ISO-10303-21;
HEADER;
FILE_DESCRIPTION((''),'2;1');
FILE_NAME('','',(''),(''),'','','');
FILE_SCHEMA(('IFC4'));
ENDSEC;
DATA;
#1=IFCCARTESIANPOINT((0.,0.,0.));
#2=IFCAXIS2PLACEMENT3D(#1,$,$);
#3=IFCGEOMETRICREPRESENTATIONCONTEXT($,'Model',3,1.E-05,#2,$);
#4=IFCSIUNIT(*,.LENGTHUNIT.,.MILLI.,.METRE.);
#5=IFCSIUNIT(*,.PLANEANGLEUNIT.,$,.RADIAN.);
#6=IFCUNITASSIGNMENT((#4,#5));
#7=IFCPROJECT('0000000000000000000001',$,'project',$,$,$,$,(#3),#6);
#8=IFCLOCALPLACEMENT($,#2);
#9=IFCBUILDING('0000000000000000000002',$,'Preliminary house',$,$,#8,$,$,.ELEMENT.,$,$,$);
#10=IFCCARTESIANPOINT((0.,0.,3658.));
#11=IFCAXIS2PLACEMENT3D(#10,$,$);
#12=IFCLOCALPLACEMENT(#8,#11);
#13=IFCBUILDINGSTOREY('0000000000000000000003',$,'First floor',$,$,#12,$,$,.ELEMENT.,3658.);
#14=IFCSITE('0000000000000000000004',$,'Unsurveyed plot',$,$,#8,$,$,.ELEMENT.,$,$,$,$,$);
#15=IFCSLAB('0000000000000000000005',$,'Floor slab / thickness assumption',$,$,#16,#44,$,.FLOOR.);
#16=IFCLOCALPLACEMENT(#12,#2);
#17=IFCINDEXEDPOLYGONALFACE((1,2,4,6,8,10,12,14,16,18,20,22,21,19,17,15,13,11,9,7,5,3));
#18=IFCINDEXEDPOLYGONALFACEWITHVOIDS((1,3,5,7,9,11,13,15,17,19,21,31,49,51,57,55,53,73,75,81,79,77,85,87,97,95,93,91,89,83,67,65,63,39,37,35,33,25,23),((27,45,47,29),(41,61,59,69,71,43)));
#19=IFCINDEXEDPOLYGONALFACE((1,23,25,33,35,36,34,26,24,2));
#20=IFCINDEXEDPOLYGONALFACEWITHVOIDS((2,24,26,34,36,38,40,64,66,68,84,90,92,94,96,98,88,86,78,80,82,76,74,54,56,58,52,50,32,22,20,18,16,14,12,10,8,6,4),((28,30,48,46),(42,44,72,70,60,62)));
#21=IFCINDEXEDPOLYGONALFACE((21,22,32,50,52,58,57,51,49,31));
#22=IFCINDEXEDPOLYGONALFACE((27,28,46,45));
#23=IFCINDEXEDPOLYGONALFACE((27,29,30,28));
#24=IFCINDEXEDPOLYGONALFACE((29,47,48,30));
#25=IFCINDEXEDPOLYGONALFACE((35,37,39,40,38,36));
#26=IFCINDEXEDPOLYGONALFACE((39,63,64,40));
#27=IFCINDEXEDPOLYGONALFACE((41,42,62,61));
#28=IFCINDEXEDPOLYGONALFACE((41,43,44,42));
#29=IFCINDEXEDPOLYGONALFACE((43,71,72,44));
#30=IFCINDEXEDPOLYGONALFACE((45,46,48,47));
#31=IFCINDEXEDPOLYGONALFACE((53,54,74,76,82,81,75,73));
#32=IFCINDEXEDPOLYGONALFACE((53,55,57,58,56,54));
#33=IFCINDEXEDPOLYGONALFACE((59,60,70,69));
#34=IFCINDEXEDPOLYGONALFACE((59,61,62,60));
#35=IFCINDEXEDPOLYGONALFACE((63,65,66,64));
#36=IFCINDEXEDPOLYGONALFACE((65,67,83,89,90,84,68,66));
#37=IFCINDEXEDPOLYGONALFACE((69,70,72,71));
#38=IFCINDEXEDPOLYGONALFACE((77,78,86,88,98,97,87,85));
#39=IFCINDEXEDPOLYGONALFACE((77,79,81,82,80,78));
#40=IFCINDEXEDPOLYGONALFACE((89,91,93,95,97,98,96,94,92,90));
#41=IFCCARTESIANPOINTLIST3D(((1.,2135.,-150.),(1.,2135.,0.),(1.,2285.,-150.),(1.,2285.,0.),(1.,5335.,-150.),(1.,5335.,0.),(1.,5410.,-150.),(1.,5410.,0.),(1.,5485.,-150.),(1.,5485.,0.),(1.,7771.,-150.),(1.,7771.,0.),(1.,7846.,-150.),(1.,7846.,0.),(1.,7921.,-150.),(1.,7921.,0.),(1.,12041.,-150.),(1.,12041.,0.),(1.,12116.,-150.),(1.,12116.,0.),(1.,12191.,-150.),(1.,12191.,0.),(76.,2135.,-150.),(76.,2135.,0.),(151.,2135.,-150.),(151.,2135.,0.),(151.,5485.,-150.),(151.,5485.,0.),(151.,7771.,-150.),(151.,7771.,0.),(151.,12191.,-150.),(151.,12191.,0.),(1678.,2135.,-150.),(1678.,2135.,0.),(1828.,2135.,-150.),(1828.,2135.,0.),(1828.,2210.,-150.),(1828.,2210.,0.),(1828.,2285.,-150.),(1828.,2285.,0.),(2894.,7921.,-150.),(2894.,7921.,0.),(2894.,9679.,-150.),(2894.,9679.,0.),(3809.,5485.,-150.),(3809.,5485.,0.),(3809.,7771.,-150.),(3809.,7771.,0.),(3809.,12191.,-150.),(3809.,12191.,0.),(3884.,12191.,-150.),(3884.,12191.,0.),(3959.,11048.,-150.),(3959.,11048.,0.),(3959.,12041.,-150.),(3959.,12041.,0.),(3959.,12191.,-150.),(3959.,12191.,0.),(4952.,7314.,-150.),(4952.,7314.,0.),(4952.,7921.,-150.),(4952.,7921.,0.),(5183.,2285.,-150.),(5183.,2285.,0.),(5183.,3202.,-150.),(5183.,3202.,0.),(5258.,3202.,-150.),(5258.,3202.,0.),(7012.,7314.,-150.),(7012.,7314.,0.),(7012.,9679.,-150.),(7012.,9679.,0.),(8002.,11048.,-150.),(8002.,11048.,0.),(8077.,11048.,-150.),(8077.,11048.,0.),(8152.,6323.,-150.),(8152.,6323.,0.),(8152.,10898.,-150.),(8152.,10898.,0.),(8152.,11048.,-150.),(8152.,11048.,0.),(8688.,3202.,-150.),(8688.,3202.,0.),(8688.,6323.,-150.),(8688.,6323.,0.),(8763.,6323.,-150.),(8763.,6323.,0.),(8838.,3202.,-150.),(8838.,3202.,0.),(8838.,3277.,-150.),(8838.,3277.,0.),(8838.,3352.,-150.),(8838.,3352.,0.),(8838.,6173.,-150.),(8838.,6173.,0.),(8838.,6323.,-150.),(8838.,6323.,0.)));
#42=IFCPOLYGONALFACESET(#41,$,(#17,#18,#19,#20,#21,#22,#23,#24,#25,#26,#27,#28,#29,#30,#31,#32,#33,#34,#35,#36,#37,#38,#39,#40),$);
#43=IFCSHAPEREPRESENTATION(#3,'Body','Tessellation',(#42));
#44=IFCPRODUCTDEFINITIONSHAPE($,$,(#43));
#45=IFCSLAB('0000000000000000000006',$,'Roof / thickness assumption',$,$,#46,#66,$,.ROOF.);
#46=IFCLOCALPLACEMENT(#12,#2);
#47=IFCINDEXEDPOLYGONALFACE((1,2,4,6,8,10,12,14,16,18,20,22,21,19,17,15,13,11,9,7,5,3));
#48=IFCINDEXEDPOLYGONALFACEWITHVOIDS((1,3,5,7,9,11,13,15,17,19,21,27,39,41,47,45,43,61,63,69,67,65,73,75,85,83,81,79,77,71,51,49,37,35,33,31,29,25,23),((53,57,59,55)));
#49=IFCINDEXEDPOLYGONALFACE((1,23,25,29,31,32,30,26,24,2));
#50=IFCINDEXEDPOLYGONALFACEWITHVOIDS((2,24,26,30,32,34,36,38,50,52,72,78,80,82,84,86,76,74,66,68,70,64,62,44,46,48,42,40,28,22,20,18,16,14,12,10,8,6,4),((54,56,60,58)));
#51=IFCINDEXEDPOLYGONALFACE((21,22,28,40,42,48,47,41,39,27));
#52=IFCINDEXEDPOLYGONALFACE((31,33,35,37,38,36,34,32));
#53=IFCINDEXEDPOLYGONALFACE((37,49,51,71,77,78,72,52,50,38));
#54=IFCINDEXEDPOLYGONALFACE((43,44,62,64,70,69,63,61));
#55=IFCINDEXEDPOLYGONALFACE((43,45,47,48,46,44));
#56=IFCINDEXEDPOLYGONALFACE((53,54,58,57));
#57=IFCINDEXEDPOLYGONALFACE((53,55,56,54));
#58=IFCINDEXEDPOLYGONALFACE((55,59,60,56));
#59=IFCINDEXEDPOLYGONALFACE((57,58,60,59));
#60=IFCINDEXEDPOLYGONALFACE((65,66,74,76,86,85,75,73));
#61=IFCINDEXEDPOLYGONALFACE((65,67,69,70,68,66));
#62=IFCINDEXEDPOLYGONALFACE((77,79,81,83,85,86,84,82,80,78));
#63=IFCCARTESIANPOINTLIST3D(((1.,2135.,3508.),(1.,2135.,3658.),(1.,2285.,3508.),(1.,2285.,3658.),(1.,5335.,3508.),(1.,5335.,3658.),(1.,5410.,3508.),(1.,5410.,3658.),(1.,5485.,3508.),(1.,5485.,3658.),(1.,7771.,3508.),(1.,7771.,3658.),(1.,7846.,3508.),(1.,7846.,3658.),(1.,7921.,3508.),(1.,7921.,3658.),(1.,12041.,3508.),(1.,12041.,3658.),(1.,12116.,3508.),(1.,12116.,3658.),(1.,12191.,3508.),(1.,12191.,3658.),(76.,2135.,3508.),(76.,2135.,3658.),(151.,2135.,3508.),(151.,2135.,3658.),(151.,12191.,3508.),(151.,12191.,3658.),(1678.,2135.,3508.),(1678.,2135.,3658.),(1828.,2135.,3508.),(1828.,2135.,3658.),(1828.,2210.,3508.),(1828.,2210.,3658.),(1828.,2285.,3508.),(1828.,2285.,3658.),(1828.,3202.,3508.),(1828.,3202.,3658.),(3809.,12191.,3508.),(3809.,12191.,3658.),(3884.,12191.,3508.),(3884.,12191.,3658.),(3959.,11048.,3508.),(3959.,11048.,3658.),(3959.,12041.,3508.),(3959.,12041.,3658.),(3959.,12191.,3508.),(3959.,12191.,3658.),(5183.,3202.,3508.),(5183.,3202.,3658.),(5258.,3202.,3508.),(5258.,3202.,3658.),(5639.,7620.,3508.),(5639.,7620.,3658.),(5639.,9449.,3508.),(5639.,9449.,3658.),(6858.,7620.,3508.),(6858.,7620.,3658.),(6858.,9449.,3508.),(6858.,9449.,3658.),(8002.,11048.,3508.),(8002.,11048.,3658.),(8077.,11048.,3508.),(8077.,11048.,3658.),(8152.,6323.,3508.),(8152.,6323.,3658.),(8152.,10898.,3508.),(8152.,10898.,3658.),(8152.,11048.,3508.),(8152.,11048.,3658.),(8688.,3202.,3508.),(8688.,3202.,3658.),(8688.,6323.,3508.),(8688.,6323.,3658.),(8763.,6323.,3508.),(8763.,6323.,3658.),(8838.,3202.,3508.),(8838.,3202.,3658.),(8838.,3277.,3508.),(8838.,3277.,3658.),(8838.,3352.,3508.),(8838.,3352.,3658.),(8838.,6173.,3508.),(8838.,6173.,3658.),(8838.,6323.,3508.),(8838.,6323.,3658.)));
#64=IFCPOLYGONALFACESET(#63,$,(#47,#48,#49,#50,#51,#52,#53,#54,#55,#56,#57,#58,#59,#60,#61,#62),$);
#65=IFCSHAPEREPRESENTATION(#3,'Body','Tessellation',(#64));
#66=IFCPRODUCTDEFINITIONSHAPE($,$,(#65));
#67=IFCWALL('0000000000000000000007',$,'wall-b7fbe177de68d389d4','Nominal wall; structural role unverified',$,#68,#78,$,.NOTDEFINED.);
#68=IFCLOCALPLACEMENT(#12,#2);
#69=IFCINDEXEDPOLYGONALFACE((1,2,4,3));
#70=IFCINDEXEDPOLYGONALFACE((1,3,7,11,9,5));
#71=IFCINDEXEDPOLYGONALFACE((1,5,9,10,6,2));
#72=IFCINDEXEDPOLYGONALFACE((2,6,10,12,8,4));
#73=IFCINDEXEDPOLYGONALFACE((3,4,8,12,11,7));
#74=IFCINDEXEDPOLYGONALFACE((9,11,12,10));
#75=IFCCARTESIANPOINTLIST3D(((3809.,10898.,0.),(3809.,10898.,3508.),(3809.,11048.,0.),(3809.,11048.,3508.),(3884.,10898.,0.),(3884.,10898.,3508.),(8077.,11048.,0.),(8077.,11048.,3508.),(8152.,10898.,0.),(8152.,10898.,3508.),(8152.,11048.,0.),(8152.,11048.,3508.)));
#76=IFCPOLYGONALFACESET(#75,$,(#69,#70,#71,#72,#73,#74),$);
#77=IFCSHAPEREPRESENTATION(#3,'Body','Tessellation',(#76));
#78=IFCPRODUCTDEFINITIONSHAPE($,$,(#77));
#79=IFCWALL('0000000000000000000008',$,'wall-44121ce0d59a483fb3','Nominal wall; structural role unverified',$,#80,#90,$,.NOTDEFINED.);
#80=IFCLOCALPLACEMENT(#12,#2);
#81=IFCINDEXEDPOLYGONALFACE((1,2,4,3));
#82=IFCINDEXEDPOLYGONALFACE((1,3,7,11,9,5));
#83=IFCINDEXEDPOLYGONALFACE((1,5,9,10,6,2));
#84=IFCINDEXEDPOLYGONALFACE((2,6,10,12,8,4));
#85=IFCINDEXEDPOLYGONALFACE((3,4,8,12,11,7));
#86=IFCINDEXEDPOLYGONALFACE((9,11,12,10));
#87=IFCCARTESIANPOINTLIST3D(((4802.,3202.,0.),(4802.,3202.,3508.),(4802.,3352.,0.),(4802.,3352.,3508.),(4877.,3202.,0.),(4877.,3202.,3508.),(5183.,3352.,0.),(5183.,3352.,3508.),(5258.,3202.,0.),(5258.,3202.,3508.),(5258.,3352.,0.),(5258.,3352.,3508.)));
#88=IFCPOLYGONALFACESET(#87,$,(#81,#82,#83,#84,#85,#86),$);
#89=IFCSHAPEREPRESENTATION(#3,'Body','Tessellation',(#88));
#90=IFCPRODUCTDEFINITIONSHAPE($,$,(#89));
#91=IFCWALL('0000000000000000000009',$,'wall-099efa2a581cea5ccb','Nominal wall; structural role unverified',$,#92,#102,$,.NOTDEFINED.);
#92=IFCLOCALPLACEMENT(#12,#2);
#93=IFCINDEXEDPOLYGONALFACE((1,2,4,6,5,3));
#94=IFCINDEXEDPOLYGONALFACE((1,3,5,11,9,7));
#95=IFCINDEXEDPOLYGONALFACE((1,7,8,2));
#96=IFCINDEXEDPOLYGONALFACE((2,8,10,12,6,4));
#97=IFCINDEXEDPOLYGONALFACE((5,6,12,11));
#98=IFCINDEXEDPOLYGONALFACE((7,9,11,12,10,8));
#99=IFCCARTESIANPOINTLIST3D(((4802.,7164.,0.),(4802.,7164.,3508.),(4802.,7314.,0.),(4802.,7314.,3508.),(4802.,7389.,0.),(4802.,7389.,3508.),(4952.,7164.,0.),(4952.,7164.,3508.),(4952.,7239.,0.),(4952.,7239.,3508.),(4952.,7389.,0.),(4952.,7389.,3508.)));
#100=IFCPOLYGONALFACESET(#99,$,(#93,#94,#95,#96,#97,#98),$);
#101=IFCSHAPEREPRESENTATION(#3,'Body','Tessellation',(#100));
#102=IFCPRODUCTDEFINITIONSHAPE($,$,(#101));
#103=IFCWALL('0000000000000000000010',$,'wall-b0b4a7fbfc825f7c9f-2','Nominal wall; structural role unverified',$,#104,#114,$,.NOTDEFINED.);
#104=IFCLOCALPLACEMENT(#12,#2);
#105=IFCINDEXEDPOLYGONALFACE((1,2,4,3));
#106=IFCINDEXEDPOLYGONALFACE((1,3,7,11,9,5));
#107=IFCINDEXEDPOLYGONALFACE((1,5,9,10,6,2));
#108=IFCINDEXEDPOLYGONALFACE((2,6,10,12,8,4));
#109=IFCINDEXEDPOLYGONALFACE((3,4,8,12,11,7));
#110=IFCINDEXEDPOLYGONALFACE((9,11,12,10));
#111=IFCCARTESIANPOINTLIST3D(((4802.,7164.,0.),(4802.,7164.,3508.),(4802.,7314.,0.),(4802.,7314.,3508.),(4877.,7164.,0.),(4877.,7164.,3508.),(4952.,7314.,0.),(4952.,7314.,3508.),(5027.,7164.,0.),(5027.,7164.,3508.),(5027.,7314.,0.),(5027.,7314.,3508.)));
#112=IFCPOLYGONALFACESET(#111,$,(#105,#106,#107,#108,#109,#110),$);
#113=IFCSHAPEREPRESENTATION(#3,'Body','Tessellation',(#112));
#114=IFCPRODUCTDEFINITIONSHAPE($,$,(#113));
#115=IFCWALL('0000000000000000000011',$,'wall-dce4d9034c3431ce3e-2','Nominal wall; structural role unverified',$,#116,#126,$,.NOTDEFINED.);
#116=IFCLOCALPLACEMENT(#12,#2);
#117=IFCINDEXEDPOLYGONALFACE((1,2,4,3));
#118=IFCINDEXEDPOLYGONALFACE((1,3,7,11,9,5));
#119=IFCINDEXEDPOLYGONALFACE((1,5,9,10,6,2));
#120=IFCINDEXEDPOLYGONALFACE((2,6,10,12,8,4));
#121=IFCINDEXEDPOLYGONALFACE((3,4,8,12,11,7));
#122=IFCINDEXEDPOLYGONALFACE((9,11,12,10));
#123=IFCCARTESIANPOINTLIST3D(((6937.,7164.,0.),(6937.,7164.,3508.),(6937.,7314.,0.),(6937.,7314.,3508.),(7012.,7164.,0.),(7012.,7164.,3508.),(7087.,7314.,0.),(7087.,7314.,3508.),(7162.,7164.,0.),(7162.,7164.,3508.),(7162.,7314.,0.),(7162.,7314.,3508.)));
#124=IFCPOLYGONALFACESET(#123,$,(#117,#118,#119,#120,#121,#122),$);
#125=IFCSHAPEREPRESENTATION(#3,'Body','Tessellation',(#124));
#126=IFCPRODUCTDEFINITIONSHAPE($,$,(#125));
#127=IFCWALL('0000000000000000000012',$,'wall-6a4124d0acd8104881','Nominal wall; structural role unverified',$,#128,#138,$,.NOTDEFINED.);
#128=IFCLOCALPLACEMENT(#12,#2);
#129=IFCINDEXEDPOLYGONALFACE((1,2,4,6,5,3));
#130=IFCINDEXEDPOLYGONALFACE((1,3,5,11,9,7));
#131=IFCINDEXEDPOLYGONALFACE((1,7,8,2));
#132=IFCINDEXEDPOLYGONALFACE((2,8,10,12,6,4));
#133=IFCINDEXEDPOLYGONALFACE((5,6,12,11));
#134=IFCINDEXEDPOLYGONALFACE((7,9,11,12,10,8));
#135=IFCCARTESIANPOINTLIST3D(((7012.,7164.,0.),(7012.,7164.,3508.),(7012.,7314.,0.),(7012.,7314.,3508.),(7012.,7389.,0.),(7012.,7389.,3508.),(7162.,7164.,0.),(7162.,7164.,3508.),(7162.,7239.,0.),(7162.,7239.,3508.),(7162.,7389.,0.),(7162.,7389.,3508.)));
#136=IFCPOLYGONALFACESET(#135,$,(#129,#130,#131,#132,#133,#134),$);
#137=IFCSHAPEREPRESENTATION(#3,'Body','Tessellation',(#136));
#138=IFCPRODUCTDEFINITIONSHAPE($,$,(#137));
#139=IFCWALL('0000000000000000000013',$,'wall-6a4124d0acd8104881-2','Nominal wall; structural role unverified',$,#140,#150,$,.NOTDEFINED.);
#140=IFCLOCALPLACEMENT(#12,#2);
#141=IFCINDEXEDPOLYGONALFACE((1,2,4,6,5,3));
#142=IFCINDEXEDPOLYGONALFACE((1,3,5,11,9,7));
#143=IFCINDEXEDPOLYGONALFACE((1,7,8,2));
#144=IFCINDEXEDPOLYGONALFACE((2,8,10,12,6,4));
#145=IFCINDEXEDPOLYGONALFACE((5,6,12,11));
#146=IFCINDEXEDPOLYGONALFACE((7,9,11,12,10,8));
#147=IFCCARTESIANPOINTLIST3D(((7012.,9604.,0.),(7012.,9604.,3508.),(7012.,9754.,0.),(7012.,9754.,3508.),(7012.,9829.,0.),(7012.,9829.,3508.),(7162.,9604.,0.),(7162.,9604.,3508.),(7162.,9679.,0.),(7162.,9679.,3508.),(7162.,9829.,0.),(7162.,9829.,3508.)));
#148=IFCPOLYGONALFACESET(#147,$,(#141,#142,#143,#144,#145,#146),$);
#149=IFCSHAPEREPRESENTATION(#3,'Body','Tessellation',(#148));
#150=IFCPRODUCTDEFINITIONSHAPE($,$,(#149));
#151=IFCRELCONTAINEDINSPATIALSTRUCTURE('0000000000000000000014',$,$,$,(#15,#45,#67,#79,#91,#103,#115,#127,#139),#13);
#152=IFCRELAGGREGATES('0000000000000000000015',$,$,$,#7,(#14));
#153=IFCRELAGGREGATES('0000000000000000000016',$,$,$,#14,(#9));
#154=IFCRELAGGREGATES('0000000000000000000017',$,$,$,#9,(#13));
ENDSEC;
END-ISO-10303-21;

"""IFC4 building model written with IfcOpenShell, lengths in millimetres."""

from ifc_helpers import new_model, si_unit, frame, origin, place, context, project, spatial, polyline, outline, extrude, element, save


model = new_model("IFC4")

# Units and contexts
model_context = context("Model", 3, precision=1e-05, world=origin())
ifc_project = project(units=[si_unit("LENGTHUNIT", "METRE", prefix="MILLI"), si_unit("PLANEANGLEUNIT", "RADIAN")], contexts=[model_context])

# Site, building, storey
placement_1 = place(None, origin())
site = spatial("IfcSite", under=ifc_project, at=placement_1, Name="Unsurveyed plot", CompositionType="ELEMENT")
building = spatial("IfcBuilding", under=site, at=placement_1, Name="Preliminary house", CompositionType="ELEMENT")
placement_2 = place(placement_1, frame((0.0, 0.0, 3658.0)))
storey = spatial("IfcBuildingStorey", under=building, at=placement_2, Name="First floor", CompositionType="ELEMENT", Elevation=3658.0)

# Slabs
element("IfcSlab", 1, at=placement_2, inside=storey, Name="Floor slab / thickness assumption", PredefinedType="FLOOR", context=model_context, shape_type="SweptSolid", body=[
    extrude(outline(polyline([(1.0, 2285.0), (1.0, 5335.0), (1.0, 5410.0), (1.0, 5485.0), (1.0, 7771.0), (1.0, 7846.0), (1.0, 7921.0), (1.0, 12041.0), (1.0, 12116.0), (1.0, 12191.0), (151.0, 12191.0), (3809.0, 12191.0), (3884.0, 12191.0), (3959.0, 12191.0), (3959.0, 12041.0), (3959.0, 11048.0), (8002.0, 11048.0), (8077.0, 11048.0), (8152.0, 11048.0), (8152.0, 10898.0), (8152.0, 6323.0), (8688.0, 6323.0), (8763.0, 6323.0), (8838.0, 6323.0), (8838.0, 6173.0), (8838.0, 3352.0), (8838.0, 3277.0), (8838.0, 3202.0), (8688.0, 3202.0), (5258.0, 3202.0), (5183.0, 3202.0), (5183.0, 2285.0), (1828.0, 2285.0), (1828.0, 2210.0), (1828.0, 2135.0), (1678.0, 2135.0), (151.0, 2135.0), (76.0, 2135.0), (1.0, 2135.0), (1.0, 2285.0)]), holes=[polyline([(7012.0, 9679.0), (2894.0, 9679.0), (2894.0, 7921.0), (4952.0, 7921.0), (4952.0, 7314.0), (7012.0, 7314.0), (7012.0, 9679.0)]), polyline([(151.0, 7771.0), (151.0, 5485.0), (3809.0, 5485.0), (3809.0, 7771.0), (151.0, 7771.0)])]), frame((0.0, 0.0, -150.0)), (0.0, 0.0, 1.0), 150.0),
])
element("IfcSlab", 2, at=placement_2, inside=storey, Name="Roof / thickness assumption", PredefinedType="ROOF", context=model_context, shape_type="SweptSolid", body=[
    extrude(outline(polyline([(1.0, 2285.0), (1.0, 5335.0), (1.0, 5410.0), (1.0, 5485.0), (1.0, 7771.0), (1.0, 7846.0), (1.0, 7921.0), (1.0, 12041.0), (1.0, 12116.0), (1.0, 12191.0), (151.0, 12191.0), (3809.0, 12191.0), (3884.0, 12191.0), (3959.0, 12191.0), (3959.0, 12041.0), (3959.0, 11048.0), (8002.0, 11048.0), (8077.0, 11048.0), (8152.0, 11048.0), (8152.0, 10898.0), (8152.0, 6323.0), (8688.0, 6323.0), (8763.0, 6323.0), (8838.0, 6323.0), (8838.0, 6173.0), (8838.0, 3352.0), (8838.0, 3277.0), (8838.0, 3202.0), (8688.0, 3202.0), (5258.0, 3202.0), (5183.0, 3202.0), (1828.0, 3202.0), (1828.0, 2285.0), (1828.0, 2210.0), (1828.0, 2135.0), (1678.0, 2135.0), (151.0, 2135.0), (76.0, 2135.0), (1.0, 2135.0), (1.0, 2285.0)]), holes=[polyline([(6858.0, 7620.0), (6858.0, 9449.0), (5639.0, 9449.0), (5639.0, 7620.0), (6858.0, 7620.0)])]), frame((0.0, 0.0, 3508.0)), (0.0, 0.0, 1.0), 150.0),
])

# Wall
element("IfcWall", 3, at=placement_2, inside=storey, Name="wall-b7fbe177de68d389d4", Description="Nominal wall; structural role unverified", PredefinedType="NOTDEFINED", context=model_context, shape_type="SweptSolid", body=[
    extrude(outline(polyline([(8077.0, 11048.0), (8152.0, 11048.0), (8152.0, 10898.0), (3884.0, 10898.0), (3809.0, 10898.0), (3809.0, 11048.0), (8077.0, 11048.0)])), origin(), (0.0, 0.0, 1.0), 3508.0),
])

# Wall
element("IfcWall", 4, at=placement_2, inside=storey, Name="wall-44121ce0d59a483fb3", Description="Nominal wall; structural role unverified", PredefinedType="NOTDEFINED", context=model_context, shape_type="SweptSolid", body=[
    extrude(outline(polyline([(5183.0, 3352.0), (5258.0, 3352.0), (5258.0, 3202.0), (4877.0, 3202.0), (4802.0, 3202.0), (4802.0, 3352.0), (5183.0, 3352.0)])), origin(), (0.0, 0.0, 1.0), 3508.0),
])

# Walls
element("IfcWall", 5, at=placement_2, inside=storey, Name="wall-099efa2a581cea5ccb", Description="Nominal wall; structural role unverified", PredefinedType="NOTDEFINED", context=model_context, shape_type="SweptSolid", body=[
    extrude(outline(polyline([(4802.0, 7314.0), (4802.0, 7389.0), (4952.0, 7389.0), (4952.0, 7239.0), (4952.0, 7164.0), (4802.0, 7164.0), (4802.0, 7314.0)])), origin(), (0.0, 0.0, 1.0), 3508.0),
])
element("IfcWall", 6, at=placement_2, inside=storey, Name="wall-b0b4a7fbfc825f7c9f-2", Description="Nominal wall; structural role unverified", PredefinedType="NOTDEFINED", context=model_context, shape_type="SweptSolid", body=[
    extrude(outline(polyline([(4952.0, 7314.0), (5027.0, 7314.0), (5027.0, 7164.0), (4877.0, 7164.0), (4802.0, 7164.0), (4802.0, 7314.0), (4952.0, 7314.0)])), origin(), (0.0, 0.0, 1.0), 3508.0),
])
element("IfcWall", 7, at=placement_2, inside=storey, Name="wall-dce4d9034c3431ce3e-2", Description="Nominal wall; structural role unverified", PredefinedType="NOTDEFINED", context=model_context, shape_type="SweptSolid", body=[
    extrude(outline(polyline([(7087.0, 7314.0), (7162.0, 7314.0), (7162.0, 7164.0), (7012.0, 7164.0), (6937.0, 7164.0), (6937.0, 7314.0), (7087.0, 7314.0)])), origin(), (0.0, 0.0, 1.0), 3508.0),
])
element("IfcWall", 8, at=placement_2, inside=storey, Name="wall-6a4124d0acd8104881", Description="Nominal wall; structural role unverified", PredefinedType="NOTDEFINED", context=model_context, shape_type="SweptSolid", body=[
    extrude(outline(polyline([(7012.0, 7314.0), (7012.0, 7389.0), (7162.0, 7389.0), (7162.0, 7239.0), (7162.0, 7164.0), (7012.0, 7164.0), (7012.0, 7314.0)])), origin(), (0.0, 0.0, 1.0), 3508.0),
])
element("IfcWall", 9, at=placement_2, inside=storey, Name="wall-6a4124d0acd8104881-2", Description="Nominal wall; structural role unverified", PredefinedType="NOTDEFINED", context=model_context, shape_type="SweptSolid", body=[
    extrude(outline(polyline([(7012.0, 9754.0), (7012.0, 9829.0), (7162.0, 9829.0), (7162.0, 9679.0), (7162.0, 9604.0), (7012.0, 9604.0), (7012.0, 9754.0)])), origin(), (0.0, 0.0, 1.0), 3508.0),
])

save(model, "model.ifc")
